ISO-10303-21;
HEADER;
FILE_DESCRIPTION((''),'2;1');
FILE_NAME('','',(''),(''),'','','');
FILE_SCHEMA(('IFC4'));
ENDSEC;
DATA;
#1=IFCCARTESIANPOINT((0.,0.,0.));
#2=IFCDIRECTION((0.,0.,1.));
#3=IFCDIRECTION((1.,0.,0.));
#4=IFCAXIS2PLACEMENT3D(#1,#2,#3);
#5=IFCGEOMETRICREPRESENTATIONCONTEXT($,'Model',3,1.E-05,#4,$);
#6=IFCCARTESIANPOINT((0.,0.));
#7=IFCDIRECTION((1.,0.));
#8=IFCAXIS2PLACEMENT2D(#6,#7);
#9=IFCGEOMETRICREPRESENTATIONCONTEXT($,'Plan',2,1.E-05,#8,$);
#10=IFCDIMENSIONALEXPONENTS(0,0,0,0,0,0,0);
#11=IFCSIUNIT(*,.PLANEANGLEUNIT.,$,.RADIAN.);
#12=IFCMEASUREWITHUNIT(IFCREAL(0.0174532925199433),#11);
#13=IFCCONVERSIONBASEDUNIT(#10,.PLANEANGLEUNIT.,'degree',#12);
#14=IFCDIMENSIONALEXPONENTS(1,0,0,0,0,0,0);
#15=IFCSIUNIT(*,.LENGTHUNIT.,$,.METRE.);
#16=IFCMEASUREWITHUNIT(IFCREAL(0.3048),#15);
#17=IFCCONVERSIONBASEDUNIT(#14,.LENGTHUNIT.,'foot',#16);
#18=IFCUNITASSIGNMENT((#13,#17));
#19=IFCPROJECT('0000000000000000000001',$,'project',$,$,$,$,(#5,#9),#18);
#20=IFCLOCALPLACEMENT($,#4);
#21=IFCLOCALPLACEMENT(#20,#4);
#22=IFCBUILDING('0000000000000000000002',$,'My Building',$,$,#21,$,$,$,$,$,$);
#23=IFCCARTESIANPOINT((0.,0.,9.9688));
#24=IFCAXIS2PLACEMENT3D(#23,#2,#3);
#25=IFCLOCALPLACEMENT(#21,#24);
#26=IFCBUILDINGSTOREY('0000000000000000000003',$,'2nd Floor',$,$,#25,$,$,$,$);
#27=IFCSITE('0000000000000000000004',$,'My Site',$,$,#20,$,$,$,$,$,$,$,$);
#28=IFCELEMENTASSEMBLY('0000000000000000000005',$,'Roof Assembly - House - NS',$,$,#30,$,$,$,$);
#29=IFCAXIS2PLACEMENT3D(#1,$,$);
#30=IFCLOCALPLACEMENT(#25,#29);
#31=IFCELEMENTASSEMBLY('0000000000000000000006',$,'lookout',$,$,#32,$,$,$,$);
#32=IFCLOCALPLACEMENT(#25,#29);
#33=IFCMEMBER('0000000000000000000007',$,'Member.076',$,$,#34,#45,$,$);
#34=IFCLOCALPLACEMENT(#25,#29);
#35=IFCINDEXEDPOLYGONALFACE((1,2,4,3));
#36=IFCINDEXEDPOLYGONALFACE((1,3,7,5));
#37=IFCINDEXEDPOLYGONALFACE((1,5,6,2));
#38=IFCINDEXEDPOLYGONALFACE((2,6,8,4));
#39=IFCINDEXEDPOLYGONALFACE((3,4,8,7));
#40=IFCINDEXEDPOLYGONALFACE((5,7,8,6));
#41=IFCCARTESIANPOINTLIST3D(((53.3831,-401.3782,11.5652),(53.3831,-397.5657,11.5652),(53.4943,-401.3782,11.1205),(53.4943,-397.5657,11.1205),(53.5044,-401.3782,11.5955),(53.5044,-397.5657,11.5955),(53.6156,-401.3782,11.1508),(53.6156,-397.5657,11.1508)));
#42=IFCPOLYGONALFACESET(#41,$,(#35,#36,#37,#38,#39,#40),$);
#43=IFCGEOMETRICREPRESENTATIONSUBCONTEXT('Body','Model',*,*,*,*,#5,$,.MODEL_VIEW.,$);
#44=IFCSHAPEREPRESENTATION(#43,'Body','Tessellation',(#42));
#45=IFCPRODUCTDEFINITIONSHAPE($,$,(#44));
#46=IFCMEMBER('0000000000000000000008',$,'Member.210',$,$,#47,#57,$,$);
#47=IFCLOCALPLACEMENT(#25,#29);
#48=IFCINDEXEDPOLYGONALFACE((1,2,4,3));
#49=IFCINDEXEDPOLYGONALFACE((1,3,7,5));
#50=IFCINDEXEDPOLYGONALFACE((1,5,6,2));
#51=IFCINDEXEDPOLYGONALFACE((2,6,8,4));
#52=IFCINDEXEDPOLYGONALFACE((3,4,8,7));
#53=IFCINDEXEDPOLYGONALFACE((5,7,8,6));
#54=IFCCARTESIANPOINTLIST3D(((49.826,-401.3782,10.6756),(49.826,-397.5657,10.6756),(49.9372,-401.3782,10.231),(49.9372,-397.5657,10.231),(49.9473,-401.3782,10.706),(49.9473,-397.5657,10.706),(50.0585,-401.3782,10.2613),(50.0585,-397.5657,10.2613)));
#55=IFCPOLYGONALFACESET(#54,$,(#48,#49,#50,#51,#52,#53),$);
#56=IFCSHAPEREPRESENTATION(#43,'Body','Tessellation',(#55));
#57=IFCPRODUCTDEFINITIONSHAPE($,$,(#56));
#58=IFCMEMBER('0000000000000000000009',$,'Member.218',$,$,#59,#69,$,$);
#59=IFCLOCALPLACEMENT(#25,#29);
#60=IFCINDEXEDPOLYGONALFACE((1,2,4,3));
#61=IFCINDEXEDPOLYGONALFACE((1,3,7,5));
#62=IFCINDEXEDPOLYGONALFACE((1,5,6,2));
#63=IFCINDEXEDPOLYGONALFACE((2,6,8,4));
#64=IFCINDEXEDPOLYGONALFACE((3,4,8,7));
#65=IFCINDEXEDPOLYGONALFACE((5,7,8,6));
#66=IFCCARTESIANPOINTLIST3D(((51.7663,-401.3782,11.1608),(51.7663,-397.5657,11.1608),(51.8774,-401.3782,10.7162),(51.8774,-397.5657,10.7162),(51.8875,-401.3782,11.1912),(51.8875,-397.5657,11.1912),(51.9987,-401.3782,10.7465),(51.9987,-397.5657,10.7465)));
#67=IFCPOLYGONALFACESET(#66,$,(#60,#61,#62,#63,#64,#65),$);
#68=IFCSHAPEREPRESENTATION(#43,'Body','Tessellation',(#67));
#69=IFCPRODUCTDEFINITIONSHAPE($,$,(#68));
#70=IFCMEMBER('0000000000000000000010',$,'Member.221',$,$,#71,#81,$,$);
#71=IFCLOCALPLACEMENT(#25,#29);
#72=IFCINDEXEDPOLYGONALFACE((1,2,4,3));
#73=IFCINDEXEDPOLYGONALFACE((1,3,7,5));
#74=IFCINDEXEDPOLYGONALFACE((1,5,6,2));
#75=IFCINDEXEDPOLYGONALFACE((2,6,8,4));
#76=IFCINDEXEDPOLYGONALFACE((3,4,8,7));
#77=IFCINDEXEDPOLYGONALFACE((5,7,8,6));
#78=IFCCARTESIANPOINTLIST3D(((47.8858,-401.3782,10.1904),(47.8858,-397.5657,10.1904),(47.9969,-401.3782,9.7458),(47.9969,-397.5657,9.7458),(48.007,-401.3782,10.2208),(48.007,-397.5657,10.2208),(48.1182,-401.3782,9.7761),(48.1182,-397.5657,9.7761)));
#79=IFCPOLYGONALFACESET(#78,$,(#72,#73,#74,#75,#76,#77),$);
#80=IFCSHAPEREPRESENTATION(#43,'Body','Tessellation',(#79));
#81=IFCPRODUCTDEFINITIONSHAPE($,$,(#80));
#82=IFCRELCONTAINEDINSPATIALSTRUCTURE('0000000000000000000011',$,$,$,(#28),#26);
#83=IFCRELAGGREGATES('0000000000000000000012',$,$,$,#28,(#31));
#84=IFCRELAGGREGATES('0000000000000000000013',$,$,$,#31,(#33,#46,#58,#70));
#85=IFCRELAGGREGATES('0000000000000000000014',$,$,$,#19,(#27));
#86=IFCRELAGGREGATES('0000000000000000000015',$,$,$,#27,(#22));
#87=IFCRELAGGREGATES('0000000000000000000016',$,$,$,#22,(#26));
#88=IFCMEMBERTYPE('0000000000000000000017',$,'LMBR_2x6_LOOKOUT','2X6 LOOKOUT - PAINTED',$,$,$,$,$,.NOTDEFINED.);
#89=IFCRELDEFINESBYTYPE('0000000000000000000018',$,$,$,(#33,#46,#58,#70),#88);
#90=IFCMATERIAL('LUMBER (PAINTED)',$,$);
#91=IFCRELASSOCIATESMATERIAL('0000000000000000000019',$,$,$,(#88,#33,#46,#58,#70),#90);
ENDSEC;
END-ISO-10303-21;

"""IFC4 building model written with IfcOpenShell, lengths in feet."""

from ifc_helpers import new_model, entity, si_unit, converted_unit, frame, origin_with_axes, origin_2d_with_axis, place, context, subcontext, project, spatial, indexed_curve, outline, extrude, material, material_profile, profile_set, profile_usage, type_object, element, aggregate, save


model = new_model("IFC4")

# Units and contexts
model_context = context("Model", 3, precision=1e-05, world=origin_with_axes())
plan_context = context("Plan", 2, precision=1e-05, world=origin_2d_with_axis())
body_context = subcontext(model_context, "Body", "Model", "MODEL_VIEW")
ifc_project = project(units=[converted_unit("PLANEANGLEUNIT", "degree", entity("IfcReal", 0.0174532925199433), si_unit("PLANEANGLEUNIT", "RADIAN"), dimensions=[0, 0, 0, 0, 0, 0, 0]), converted_unit("LENGTHUNIT", "foot", entity("IfcReal", 0.3048), si_unit("LENGTHUNIT", "METRE"), dimensions=[1, 0, 0, 0, 0, 0, 0])], contexts=[model_context, plan_context])

# Site, building, storey
site_placement = place(None, origin_with_axes())
site = spatial("IfcSite", under=ifc_project, at=site_placement, Name="My Site")
building_placement = place(site_placement, origin_with_axes())
building = spatial("IfcBuilding", under=site, at=building_placement, Name="My Building")
storey_placement = place(building_placement, frame((0.0, 0.0, 9.9688), z_axis=(0.0, 0.0, 1.0), x_axis=(1.0, 0.0, 0.0)))
storey = spatial("IfcBuildingStorey", under=building, at=storey_placement, Name="2nd Floor")

# Element assemblies, members
assembly_1_placement = place(storey_placement, frame((0.0, 0.0, -9.9688), z_axis=(0.0, 0.0, 1.0), x_axis=(1.0, 0.0, 0.0)))
assembly_1 = element("IfcElementAssembly", 1, at=assembly_1_placement, inside=storey, Name="Roof Assembly - House - NS")
ifc_material = material(Name="LUMBER (PAINTED)")
assembly_2_placement = place(assembly_1_placement, frame((53.6914, -397.5032, 21.6754), z_axis=(0.0, 0.0, 1.0), x_axis=(-1.0, 0.0, 0.0)))
assembly_2 = element("IfcElementAssembly", 2, at=assembly_2_placement, Name="lookout")
aggregate(assembly_1, [assembly_2])
ifc_material_profile_1 = material_profile(ifc_material, outline(indexed_curve([(-0.0625, 0.2292), (0.0625, 0.2292), (0.0625, -0.2292), (-0.0625, -0.2292), (-0.0625, 0.2292)])))
ifc_profile_set_1 = profile_set([ifc_material_profile_1])
ifc_profile_usage_1 = profile_usage(ifc_profile_set_1)
member_type_1 = type_object("IfcMemberType", Name="LMBR_2x6_LOOKOUT", Description="2X6 LOOKOUT - PAINTED", PredefinedType="NOTDEFINED", material=ifc_profile_set_1)
member_1_placement = place(assembly_2_placement, frame((0.192, 0.0625, -0.3487), z_axis=(0.0, 1.0, 0.0), x_axis=(-0.970127, 0.0, 0.242599)))
member_1 = element("IfcMember", 3, at=member_1_placement, type_object=member_type_1, material=ifc_profile_usage_1, Name="Member.076", context=body_context, shape_type="SweptSolid", body=[
    extrude(outline(indexed_curve([(-0.0625, 0.2292), (0.0625, 0.2292), (0.0625, -0.2292), (-0.0625, -0.2292), (-0.0625, 0.2292)])), origin_with_axes(), (0.0, 0.0, 1.0), 3.8125),
])
ifc_profile_usage_2 = profile_usage(ifc_profile_set_1)
member_2_placement = place(assembly_2_placement, frame((3.7491, 0.0625, -1.2382), z_axis=(0.0, 1.0, 0.0), x_axis=(-0.970127, 0.0, 0.242599)))
member_2 = element("IfcMember", 4, at=member_2_placement, type_object=member_type_1, material=ifc_profile_usage_2, Name="Member.210", context=body_context, shape_type="SweptSolid", body=[
    extrude(outline(indexed_curve([(-0.0625, 0.2292), (0.0625, 0.2292), (0.0625, -0.2292), (-0.0625, -0.2292), (-0.0625, 0.2292)])), origin_with_axes(), (0.0, 0.0, 1.0), 3.8125),
])
ifc_profile_usage_3 = profile_usage(ifc_profile_set_1)
member_3_placement = place(assembly_2_placement, frame((1.8089, 0.0625, -0.753), z_axis=(0.0, 1.0, 0.0), x_axis=(-0.970127, 0.0, 0.242599)))
member_3 = element("IfcMember", 5, at=member_3_placement, type_object=member_type_1, material=ifc_profile_usage_3, Name="Member.218", context=body_context, shape_type="SweptSolid", body=[
    extrude(outline(indexed_curve([(-0.0625, 0.2292), (0.0625, 0.2292), (0.0625, -0.2292), (-0.0625, -0.2292), (-0.0625, 0.2292)])), origin_with_axes(), (0.0, 0.0, 1.0), 3.8125),
])
ifc_profile_usage_4 = profile_usage(ifc_profile_set_1)
member_4_placement = place(assembly_2_placement, frame((5.6894, 0.0625, -1.7234), z_axis=(0.0, 1.0, 0.0), x_axis=(-0.970127, 0.0, 0.242599)))
member_4 = element("IfcMember", 6, at=member_4_placement, type_object=member_type_1, material=ifc_profile_usage_4, Name="Member.221", context=body_context, shape_type="SweptSolid", body=[
    extrude(outline(indexed_curve([(-0.0625, 0.2292), (0.0625, 0.2292), (0.0625, -0.2292), (-0.0625, -0.2292), (-0.0625, 0.2292)])), origin_with_axes(), (0.0, 0.0, 1.0), 3.8125),
])
aggregate(assembly_2, [member_1, member_2, member_3, member_4])

save(model, "model.ifc")
